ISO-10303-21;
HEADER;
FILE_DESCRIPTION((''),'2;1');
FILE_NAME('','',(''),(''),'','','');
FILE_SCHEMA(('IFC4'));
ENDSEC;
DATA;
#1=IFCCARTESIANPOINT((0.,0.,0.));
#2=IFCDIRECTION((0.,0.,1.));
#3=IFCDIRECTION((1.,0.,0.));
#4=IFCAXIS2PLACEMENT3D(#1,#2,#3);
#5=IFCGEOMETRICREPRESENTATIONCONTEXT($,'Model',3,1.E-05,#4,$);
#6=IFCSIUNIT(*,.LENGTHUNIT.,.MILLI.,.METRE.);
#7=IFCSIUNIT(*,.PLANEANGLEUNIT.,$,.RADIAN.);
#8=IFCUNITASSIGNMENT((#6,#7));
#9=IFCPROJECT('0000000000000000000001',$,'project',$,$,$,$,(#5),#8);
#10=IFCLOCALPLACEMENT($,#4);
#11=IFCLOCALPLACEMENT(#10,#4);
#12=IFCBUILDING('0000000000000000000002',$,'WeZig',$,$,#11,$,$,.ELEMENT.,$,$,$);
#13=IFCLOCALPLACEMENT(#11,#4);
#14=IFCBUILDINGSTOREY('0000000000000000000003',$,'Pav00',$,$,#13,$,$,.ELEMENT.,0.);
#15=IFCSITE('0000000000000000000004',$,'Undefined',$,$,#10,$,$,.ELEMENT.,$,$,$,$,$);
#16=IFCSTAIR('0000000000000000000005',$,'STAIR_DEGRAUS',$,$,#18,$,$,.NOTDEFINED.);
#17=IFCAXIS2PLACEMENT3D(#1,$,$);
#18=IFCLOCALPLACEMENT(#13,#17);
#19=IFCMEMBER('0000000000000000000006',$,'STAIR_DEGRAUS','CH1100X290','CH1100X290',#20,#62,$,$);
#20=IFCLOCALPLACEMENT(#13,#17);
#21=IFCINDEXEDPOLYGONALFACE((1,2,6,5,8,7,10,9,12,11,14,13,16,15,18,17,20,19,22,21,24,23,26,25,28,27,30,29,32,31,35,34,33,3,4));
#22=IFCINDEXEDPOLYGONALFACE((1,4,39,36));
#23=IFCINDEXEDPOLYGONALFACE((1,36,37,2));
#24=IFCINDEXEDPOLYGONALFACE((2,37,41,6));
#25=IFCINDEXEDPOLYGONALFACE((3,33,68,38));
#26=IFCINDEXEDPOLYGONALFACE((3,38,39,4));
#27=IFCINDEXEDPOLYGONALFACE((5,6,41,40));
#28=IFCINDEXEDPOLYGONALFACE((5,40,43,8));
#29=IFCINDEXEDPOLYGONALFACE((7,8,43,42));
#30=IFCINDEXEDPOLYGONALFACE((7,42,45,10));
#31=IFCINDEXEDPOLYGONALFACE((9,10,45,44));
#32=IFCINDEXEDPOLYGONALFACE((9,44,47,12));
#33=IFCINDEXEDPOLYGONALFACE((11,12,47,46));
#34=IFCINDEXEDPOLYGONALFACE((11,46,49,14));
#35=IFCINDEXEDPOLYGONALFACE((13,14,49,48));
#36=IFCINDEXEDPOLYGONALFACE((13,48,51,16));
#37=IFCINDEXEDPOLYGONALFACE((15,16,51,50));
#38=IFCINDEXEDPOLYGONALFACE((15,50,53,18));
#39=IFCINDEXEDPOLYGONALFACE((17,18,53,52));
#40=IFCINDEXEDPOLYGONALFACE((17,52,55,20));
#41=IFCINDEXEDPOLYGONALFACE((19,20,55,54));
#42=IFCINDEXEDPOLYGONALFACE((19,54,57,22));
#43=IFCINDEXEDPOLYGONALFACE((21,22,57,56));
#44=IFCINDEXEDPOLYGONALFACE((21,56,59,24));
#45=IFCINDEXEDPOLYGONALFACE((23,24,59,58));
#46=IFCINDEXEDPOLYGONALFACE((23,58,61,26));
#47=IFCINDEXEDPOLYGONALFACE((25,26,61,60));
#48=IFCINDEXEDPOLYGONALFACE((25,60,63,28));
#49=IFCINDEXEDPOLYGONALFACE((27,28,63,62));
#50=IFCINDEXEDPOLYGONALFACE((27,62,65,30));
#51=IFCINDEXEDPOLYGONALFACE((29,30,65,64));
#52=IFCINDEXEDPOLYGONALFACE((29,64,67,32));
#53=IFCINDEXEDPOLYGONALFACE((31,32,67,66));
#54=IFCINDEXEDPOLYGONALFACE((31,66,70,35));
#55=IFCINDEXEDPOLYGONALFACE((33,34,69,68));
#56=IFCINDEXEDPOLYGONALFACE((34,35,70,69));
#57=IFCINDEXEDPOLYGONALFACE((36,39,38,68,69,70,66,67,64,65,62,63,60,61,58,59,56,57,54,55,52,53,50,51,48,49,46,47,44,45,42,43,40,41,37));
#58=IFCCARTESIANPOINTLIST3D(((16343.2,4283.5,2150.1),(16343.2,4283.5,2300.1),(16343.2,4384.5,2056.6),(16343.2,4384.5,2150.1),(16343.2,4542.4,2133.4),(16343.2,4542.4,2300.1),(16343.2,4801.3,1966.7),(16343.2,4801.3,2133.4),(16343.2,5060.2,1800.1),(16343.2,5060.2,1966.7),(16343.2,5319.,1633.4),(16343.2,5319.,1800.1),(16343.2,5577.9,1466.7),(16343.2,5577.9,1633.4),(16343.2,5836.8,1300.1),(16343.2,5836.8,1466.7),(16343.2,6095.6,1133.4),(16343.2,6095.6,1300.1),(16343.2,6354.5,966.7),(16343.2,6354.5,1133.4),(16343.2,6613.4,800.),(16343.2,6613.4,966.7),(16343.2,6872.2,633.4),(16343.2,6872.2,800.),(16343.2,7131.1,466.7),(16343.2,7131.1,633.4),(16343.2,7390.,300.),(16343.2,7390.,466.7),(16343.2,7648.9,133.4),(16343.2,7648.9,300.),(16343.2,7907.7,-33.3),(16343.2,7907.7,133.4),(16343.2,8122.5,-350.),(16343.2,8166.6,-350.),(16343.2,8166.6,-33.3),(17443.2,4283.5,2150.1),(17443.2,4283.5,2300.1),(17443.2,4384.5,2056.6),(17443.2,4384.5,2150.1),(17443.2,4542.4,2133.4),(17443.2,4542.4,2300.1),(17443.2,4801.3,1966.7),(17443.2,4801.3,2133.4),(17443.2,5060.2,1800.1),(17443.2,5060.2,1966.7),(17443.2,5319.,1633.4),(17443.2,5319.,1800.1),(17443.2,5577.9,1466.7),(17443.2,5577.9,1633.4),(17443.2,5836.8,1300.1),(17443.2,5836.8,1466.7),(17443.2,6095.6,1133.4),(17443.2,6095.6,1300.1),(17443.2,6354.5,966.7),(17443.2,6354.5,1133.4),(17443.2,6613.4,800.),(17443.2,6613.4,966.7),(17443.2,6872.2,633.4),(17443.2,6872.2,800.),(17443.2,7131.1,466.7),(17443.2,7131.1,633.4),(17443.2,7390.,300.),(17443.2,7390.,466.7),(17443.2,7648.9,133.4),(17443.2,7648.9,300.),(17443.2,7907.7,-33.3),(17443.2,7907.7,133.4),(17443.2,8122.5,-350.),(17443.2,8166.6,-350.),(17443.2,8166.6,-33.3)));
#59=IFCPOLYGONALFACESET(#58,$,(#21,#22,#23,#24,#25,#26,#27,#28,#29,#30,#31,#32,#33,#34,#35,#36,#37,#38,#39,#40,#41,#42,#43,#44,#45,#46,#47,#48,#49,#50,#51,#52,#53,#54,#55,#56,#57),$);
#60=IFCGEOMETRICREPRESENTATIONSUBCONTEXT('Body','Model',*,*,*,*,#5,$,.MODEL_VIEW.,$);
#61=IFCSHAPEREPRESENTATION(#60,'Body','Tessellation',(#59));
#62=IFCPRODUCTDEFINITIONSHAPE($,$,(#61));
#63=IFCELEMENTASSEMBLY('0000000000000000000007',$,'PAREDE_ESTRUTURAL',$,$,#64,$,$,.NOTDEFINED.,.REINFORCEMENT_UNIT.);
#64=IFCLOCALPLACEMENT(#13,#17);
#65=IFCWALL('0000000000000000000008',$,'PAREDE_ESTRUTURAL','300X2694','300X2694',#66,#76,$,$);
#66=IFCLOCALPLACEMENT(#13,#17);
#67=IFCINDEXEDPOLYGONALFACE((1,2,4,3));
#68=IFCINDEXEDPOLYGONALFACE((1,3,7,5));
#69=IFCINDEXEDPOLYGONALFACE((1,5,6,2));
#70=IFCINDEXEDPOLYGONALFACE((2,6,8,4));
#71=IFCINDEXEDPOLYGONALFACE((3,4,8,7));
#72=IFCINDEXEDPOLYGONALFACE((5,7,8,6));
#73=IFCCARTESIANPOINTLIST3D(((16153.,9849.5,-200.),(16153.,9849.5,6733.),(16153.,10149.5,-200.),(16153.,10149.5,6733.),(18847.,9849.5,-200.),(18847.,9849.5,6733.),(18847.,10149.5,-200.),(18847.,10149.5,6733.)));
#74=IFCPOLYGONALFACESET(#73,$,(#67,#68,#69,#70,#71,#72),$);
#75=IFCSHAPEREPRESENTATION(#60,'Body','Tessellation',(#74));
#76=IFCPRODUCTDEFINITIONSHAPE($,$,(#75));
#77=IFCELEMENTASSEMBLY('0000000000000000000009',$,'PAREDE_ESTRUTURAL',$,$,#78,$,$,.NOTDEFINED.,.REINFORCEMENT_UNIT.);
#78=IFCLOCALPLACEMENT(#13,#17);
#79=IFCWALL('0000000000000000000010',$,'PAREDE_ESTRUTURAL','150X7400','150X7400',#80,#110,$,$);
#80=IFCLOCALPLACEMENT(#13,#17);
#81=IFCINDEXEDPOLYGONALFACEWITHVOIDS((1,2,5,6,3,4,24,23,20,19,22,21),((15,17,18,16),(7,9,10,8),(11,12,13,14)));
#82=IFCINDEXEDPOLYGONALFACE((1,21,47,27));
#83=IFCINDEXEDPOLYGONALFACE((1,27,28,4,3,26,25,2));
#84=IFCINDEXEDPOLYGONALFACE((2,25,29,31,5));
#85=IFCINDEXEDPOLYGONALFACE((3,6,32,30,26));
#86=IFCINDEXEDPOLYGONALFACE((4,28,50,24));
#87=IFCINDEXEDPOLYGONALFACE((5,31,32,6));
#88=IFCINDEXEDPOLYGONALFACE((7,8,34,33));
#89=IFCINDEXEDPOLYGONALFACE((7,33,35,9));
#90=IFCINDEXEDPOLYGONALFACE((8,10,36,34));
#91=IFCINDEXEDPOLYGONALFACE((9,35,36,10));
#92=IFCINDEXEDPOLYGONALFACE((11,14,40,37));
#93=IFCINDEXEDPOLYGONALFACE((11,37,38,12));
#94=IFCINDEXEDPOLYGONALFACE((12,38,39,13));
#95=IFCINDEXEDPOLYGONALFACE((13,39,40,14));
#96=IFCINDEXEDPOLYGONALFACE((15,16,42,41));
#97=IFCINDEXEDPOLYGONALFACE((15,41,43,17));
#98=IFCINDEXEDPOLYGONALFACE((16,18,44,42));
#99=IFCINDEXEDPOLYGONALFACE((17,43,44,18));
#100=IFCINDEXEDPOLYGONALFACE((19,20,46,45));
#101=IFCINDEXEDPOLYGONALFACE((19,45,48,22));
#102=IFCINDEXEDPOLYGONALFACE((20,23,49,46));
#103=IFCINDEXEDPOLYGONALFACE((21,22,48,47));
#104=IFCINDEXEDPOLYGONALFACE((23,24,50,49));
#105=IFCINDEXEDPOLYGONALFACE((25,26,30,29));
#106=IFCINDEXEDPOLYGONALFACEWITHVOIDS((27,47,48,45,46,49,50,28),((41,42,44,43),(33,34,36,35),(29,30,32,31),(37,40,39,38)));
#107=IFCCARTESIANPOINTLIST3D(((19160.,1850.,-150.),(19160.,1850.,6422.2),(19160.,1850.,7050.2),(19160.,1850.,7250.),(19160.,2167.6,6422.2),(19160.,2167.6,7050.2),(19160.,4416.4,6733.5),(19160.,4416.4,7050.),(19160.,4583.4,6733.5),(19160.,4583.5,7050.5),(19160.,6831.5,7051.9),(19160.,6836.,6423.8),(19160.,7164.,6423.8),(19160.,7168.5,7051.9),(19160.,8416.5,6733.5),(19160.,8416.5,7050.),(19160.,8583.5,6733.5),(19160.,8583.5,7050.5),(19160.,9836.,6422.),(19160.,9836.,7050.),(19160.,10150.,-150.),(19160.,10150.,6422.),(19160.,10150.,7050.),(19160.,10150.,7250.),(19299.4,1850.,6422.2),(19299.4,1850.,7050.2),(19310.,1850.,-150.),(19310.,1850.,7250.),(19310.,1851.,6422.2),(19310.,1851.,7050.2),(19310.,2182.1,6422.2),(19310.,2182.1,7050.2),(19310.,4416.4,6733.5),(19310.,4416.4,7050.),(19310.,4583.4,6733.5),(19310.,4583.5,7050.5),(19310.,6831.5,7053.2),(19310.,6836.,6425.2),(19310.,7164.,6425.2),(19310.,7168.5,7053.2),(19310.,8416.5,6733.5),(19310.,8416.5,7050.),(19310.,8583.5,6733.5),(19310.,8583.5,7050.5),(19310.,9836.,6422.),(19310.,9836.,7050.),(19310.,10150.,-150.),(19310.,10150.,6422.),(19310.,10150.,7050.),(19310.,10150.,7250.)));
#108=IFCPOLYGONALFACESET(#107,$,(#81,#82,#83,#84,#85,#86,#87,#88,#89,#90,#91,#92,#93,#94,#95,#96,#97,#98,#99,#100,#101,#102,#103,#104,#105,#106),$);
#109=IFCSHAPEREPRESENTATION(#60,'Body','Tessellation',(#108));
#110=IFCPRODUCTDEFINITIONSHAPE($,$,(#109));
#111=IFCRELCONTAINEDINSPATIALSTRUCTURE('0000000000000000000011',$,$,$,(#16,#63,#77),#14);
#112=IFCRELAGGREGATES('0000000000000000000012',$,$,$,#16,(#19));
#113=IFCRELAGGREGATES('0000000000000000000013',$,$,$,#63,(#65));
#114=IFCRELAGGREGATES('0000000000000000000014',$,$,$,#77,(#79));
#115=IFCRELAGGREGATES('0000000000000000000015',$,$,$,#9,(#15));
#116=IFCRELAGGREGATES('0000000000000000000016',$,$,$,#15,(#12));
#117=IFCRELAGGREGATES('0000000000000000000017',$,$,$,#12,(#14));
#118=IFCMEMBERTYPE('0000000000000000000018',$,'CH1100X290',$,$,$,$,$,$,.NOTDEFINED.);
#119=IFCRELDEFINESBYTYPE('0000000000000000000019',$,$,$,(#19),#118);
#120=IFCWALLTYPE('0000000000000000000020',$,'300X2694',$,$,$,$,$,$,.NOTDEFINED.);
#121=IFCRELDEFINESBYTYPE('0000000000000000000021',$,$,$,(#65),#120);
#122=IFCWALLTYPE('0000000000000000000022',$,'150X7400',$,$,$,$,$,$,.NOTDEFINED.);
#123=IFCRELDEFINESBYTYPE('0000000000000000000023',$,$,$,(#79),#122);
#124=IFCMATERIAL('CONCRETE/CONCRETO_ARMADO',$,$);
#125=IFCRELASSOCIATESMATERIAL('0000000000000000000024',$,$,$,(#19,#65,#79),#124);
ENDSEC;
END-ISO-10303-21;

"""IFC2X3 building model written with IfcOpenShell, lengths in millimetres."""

from ifc_helpers import new_model, si_unit, frame, frame_2d, origin_with_axes, place, context, subcontext, project, spatial, polyline, rectangle, outline, extrude, boolean, material, type_object, element, aggregate, save


model = new_model("IFC2X3")

# Units and contexts
model_context = context("Model", 3, precision=1e-05, world=origin_with_axes())
body_context = subcontext(model_context, "Body", "Model", "MODEL_VIEW")
ifc_project = project(units=[si_unit("LENGTHUNIT", "METRE", prefix="MILLI"), si_unit("PLANEANGLEUNIT", "RADIAN")], contexts=[model_context])

# Site, building, storey
site_placement = place(None, origin_with_axes())
site = spatial("IfcSite", under=ifc_project, at=site_placement, Name="Undefined", CompositionType="ELEMENT")
building_placement = place(site_placement, origin_with_axes())
building = spatial("IfcBuilding", under=site, at=building_placement, Name="WeZig", CompositionType="ELEMENT")
storey_placement = place(building_placement, origin_with_axes())
storey = spatial("IfcBuildingStorey", under=building, at=storey_placement, Name="Pav00", CompositionType="ELEMENT", Elevation=0.0)

# Stair, member
stair_placement = place(storey_placement, origin_with_axes())
stair = element("IfcStair", 1, at=stair_placement, inside=storey, Name="STAIR_DEGRAUS", ShapeType="NOTDEFINED")
ifc_material_1 = material(Name="CONCRETE/CONCRETO_ARMADO")
member_type = type_object("IfcMemberType", Name="CH1100X290", PredefinedType="NOTDEFINED")
member_placement = place(stair_placement, frame((16893.2, 8166.6, -33.3), z_axis=(-1.0, 0.0, 0.0), x_axis=(0.0, 0.0, -1.0)))
solid = boolean("DIFFERENCE", boolean("DIFFERENCE", boolean("DIFFERENCE", boolean("DIFFERENCE", boolean("DIFFERENCE", boolean("DIFFERENCE", boolean("DIFFERENCE", boolean("DIFFERENCE", extrude(outline(polyline([(0.0, 0.0), (316.7, 0.0), (316.7, 44.1), (-2090.0, 3782.1), (-2183.4, 3782.1), (-2183.4, 3883.1), (-2333.4, 3883.1), (-2333.4, 3624.2), (0.0, 0.0)])), frame((0.0, 0.0, -550.0), z_axis=(0.0, 0.0, 1.0), x_axis=(1.0, 0.0, 0.0)), (0.0, 0.0, 1.0), 1100.0), extrude(outline(polyline([(0.0, 0.0), (216.7, 0.0), (216.7, 258.9), (0.0, 258.9), (0.0, 0.0)])), frame((-2383.4, 3365.3, -560.0), z_axis=(0.0, 0.0, 1.0), x_axis=(1.0, 0.0, 0.0)), (0.0, 0.0, 1.0), 1120.0)), extrude(outline(polyline([(0.0, 0.0), (216.7, 0.0), (216.7, 258.9), (0.0, 258.9), (0.0, 0.0)])), frame((-2216.7, 3106.4, -560.0), z_axis=(0.0, 0.0, 1.0), x_axis=(1.0, 0.0, 0.0)), (0.0, 0.0, 1.0), 1120.0)), extrude(outline(polyline([(0.0, 0.0), (216.7, 0.0), (216.7, 258.9), (0.0, 258.9), (0.0, 0.0)])), frame((-2050.0, 2847.6, -560.0), z_axis=(0.0, 0.0, 1.0), x_axis=(1.0, 0.0, 0.0)), (0.0, 0.0, 1.0), 1120.0)), extrude(outline(polyline([(0.0, 0.0), (216.7, 0.0), (216.7, 258.9), (0.0, 258.9), (0.0, 0.0)])), frame((-1883.4, 2588.7, -560.0), z_axis=(0.0, 0.0, 1.0), x_axis=(1.0, 0.0, 0.0)), (0.0, 0.0, 1.0), 1120.0)), extrude(outline(polyline([(0.0, 0.0), (216.7, 0.0), (216.7, 258.9), (0.0, 258.9), (0.0, 0.0)])), frame((-1716.7, 2329.8, -560.0), z_axis=(0.0, 0.0, 1.0), x_axis=(1.0, 0.0, 0.0)), (0.0, 0.0, 1.0), 1120.0)), extrude(outline(polyline([(0.0, 0.0), (216.7, 0.0), (216.7, 258.9), (0.0, 258.9), (0.0, 0.0)])), frame((-1550.0, 2071.0, -560.0), z_axis=(0.0, 0.0, 1.0), x_axis=(1.0, 0.0, 0.0)), (0.0, 0.0, 1.0), 1120.0)), extrude(outline(polyline([(0.0, 0.0), (216.7, 0.0), (216.7, 258.9), (0.0, 258.9), (0.0, 0.0)])), frame((-1383.4, 1812.1, -560.0), z_axis=(0.0, 0.0, 1.0), x_axis=(1.0, 0.0, 0.0)), (0.0, 0.0, 1.0), 1120.0)), extrude(outline(polyline([(0.0, 0.0), (216.7, 0.0), (216.7, 258.9), (0.0, 258.9), (0.0, 0.0)])), frame((-1216.7, 1553.2, -560.0), z_axis=(0.0, 0.0, 1.0), x_axis=(1.0, 0.0, 0.0)), (0.0, 0.0, 1.0), 1120.0))
member = element("IfcMember", 2, at=member_placement, type_object=member_type, material=ifc_material_1, Name="STAIR_DEGRAUS", Description="CH1100X290", ObjectType="CH1100X290", context=body_context, shape_type="CSG", body=[
    boolean("DIFFERENCE", boolean("DIFFERENCE", boolean("DIFFERENCE", boolean("DIFFERENCE", boolean("DIFFERENCE", boolean("DIFFERENCE", boolean("DIFFERENCE", solid, extrude(outline(polyline([(0.0, 0.0), (216.7, 0.0), (216.7, 258.9), (0.0, 258.9), (0.0, 0.0)])), frame((-1050.0, 1294.3, -560.0), z_axis=(0.0, 0.0, 1.0), x_axis=(1.0, 0.0, 0.0)), (0.0, 0.0, 1.0), 1120.0)), extrude(outline(polyline([(0.0, 0.0), (216.7, 0.0), (216.7, 258.9), (0.0, 258.9), (0.0, 0.0)])), frame((-883.4, 1035.5, -560.0), z_axis=(0.0, 0.0, 1.0), x_axis=(1.0, 0.0, 0.0)), (0.0, 0.0, 1.0), 1120.0)), extrude(outline(polyline([(0.0, 0.0), (216.7, 0.0), (216.7, 258.9), (0.0, 258.9), (0.0, 0.0)])), frame((-716.7, 776.6, -560.0), z_axis=(0.0, 0.0, 1.0), x_axis=(1.0, 0.0, 0.0)), (0.0, 0.0, 1.0), 1120.0)), extrude(outline(polyline([(0.0, 0.0), (216.7, 0.0), (216.7, 258.9), (0.0, 258.9), (0.0, 0.0)])), frame((-550.0, 517.7, -560.0), z_axis=(0.0, 0.0, 1.0), x_axis=(1.0, 0.0, 0.0)), (0.0, 0.0, 1.0), 1120.0)), extrude(outline(polyline([(0.0, 0.0), (216.7, 0.0), (216.7, 258.9), (0.0, 258.9), (0.0, 0.0)])), frame((-383.3, 258.9, -560.0), z_axis=(0.0, 0.0, 1.0), x_axis=(1.0, 0.0, 0.0)), (0.0, 0.0, 1.0), 1120.0)), extrude(outline(polyline([(0.0, 0.0), (216.7, 0.0), (216.7, 258.9), (0.0, 258.9), (0.0, 0.0)])), frame((-216.7, 0.0, -560.0), z_axis=(0.0, 0.0, 1.0), x_axis=(1.0, 0.0, 0.0)), (0.0, 0.0, 1.0), 1120.0)), extrude(outline(polyline([(0.0, 0.0), (216.7, 0.0), (216.7, 258.9), (0.0, 258.9), (0.0, 0.0)])), frame((-50.0, -258.9, -560.0), z_axis=(0.0, 0.0, 1.0), x_axis=(1.0, 0.0, 0.0)), (0.0, 0.0, 1.0), 1120.0)),
])
aggregate(stair, [member])

# Element assemblies, walls
assembly_1_placement = place(storey_placement, origin_with_axes())
assembly_1 = element("IfcElementAssembly", 3, at=assembly_1_placement, inside=storey, Name="PAREDE_ESTRUTURAL", AssemblyPlace="NOTDEFINED", PredefinedType="REINFORCEMENT_UNIT")
wall_type_1 = type_object("IfcWallType", Name="300X2694", PredefinedType="NOTDEFINED")
wall_1_placement = place(assembly_1_placement, frame((18847.0, 9999.5, 1919.5), z_axis=(0.0, 0.0, 1.0), x_axis=(-1.0, 0.0, 0.0)))
wall_1 = element("IfcWall", 4, at=wall_1_placement, type_object=wall_type_1, material=ifc_material_1, Name="PAREDE_ESTRUTURAL", Description="300X2694", ObjectType="300X2694", context=body_context, shape_type="SweptSolid", body=[
    extrude(rectangle(XDim=2694.0, YDim=300.0, at=frame_2d((0.0, 1347.0), x_axis=(0.0, -1.0))), frame((0.0, 0.0, -2119.5), z_axis=(0.0, 0.0, 1.0), x_axis=(0.0, -1.0, 0.0)), (0.0, 0.0, 1.0), 6933.0),
])
assembly_2_placement = place(storey_placement, origin_with_axes())
assembly_2 = element("IfcElementAssembly", 5, at=assembly_2_placement, inside=storey, Name="PAREDE_ESTRUTURAL", AssemblyPlace="NOTDEFINED", PredefinedType="REINFORCEMENT_UNIT")
wall_type_2 = type_object("IfcWallType", Name="150X7400", PredefinedType="NOTDEFINED")
wall_2_placement = place(assembly_2_placement, frame((19235.0, 10150.0, -150.0), z_axis=(0.0, 0.0, 1.0), x_axis=(0.000004, -1.0, 0.0)))
wall_2 = element("IfcWall", 6, at=wall_2_placement, type_object=wall_type_2, material=ifc_material_1, Name="PAREDE_ESTRUTURAL", Description="150X7400", ObjectType="150X7400", context=body_context, shape_type="CSG", body=[
    boolean("DIFFERENCE", boolean("DIFFERENCE", boolean("DIFFERENCE", boolean("DIFFERENCE", boolean("DIFFERENCE", extrude(rectangle(XDim=8300.0, YDim=150.0, at=frame_2d((0.0, 4150.0), x_axis=(0.0, -1.0))), frame((0.0, 0.0, 0.0), z_axis=(0.0, 0.0, 1.0), x_axis=(0.0, -1.0, 0.0)), (0.0, 0.0, 1.0), 7400.0), extrude(outline(polyline([(0.0, 0.0), (167.0, 0.0), (167.0, 316.5), (0.0, 317.0), (0.0, 0.0)])), frame((1566.5, 77.5, 6883.5), z_axis=(0.0, -1.0, 0.0), x_axis=(1.0, 0.0, 0.0)), (0.0, 0.0, 1.0), 155.0)), extrude(outline(polyline([(0.0, 0.0), (167.0, 0.0), (167.0, 317.0), (0.0, 316.5), (0.0, 0.0)])), frame((5733.6, -77.5, 6883.5), z_axis=(0.0, 1.0, 0.0), x_axis=(-1.0, 0.0, 0.0)), (0.0, 0.0, 1.0), 155.0)), extrude(outline(polyline([(0.0, 0.0), (328.0, 0.0), (328.0, 628.0), (0.0, 628.0), (0.0, 0.0)])), frame((-14.0, -78.0, 7200.0), z_axis=(0.000004, 1.0, 0.0), x_axis=(1.0, -0.000004, 0.0)), (0.0, 0.0, 1.0), 156.0)), extrude(outline(polyline([(0.0, 0.0), (337.0, 0.0), (332.5, 628.0), (4.5, 628.0), (0.0, 0.0)])), frame((3318.5, 79.5, 7203.2), z_axis=(-0.000004, -0.999962, -0.008713), x_axis=(-1.0, 0.000004, 0.0)), (0.0, 0.0, 1.0), 220.0)), extrude(outline(polyline([(0.0, 0.0), (628.0, 0.0), (628.0, 329.5), (0.0, 329.5), (0.0, 0.0)])), frame((7894.0, 840.4, 7200.2), z_axis=(0.096165, -0.995365, 0.0), x_axis=(0.0, 0.0, -1.0)), (0.0, 0.0, 1.0), 953.0)),
])

aggregate(assembly_1, [wall_1])
aggregate(assembly_2, [wall_2])

save(model, "model.ifc")
